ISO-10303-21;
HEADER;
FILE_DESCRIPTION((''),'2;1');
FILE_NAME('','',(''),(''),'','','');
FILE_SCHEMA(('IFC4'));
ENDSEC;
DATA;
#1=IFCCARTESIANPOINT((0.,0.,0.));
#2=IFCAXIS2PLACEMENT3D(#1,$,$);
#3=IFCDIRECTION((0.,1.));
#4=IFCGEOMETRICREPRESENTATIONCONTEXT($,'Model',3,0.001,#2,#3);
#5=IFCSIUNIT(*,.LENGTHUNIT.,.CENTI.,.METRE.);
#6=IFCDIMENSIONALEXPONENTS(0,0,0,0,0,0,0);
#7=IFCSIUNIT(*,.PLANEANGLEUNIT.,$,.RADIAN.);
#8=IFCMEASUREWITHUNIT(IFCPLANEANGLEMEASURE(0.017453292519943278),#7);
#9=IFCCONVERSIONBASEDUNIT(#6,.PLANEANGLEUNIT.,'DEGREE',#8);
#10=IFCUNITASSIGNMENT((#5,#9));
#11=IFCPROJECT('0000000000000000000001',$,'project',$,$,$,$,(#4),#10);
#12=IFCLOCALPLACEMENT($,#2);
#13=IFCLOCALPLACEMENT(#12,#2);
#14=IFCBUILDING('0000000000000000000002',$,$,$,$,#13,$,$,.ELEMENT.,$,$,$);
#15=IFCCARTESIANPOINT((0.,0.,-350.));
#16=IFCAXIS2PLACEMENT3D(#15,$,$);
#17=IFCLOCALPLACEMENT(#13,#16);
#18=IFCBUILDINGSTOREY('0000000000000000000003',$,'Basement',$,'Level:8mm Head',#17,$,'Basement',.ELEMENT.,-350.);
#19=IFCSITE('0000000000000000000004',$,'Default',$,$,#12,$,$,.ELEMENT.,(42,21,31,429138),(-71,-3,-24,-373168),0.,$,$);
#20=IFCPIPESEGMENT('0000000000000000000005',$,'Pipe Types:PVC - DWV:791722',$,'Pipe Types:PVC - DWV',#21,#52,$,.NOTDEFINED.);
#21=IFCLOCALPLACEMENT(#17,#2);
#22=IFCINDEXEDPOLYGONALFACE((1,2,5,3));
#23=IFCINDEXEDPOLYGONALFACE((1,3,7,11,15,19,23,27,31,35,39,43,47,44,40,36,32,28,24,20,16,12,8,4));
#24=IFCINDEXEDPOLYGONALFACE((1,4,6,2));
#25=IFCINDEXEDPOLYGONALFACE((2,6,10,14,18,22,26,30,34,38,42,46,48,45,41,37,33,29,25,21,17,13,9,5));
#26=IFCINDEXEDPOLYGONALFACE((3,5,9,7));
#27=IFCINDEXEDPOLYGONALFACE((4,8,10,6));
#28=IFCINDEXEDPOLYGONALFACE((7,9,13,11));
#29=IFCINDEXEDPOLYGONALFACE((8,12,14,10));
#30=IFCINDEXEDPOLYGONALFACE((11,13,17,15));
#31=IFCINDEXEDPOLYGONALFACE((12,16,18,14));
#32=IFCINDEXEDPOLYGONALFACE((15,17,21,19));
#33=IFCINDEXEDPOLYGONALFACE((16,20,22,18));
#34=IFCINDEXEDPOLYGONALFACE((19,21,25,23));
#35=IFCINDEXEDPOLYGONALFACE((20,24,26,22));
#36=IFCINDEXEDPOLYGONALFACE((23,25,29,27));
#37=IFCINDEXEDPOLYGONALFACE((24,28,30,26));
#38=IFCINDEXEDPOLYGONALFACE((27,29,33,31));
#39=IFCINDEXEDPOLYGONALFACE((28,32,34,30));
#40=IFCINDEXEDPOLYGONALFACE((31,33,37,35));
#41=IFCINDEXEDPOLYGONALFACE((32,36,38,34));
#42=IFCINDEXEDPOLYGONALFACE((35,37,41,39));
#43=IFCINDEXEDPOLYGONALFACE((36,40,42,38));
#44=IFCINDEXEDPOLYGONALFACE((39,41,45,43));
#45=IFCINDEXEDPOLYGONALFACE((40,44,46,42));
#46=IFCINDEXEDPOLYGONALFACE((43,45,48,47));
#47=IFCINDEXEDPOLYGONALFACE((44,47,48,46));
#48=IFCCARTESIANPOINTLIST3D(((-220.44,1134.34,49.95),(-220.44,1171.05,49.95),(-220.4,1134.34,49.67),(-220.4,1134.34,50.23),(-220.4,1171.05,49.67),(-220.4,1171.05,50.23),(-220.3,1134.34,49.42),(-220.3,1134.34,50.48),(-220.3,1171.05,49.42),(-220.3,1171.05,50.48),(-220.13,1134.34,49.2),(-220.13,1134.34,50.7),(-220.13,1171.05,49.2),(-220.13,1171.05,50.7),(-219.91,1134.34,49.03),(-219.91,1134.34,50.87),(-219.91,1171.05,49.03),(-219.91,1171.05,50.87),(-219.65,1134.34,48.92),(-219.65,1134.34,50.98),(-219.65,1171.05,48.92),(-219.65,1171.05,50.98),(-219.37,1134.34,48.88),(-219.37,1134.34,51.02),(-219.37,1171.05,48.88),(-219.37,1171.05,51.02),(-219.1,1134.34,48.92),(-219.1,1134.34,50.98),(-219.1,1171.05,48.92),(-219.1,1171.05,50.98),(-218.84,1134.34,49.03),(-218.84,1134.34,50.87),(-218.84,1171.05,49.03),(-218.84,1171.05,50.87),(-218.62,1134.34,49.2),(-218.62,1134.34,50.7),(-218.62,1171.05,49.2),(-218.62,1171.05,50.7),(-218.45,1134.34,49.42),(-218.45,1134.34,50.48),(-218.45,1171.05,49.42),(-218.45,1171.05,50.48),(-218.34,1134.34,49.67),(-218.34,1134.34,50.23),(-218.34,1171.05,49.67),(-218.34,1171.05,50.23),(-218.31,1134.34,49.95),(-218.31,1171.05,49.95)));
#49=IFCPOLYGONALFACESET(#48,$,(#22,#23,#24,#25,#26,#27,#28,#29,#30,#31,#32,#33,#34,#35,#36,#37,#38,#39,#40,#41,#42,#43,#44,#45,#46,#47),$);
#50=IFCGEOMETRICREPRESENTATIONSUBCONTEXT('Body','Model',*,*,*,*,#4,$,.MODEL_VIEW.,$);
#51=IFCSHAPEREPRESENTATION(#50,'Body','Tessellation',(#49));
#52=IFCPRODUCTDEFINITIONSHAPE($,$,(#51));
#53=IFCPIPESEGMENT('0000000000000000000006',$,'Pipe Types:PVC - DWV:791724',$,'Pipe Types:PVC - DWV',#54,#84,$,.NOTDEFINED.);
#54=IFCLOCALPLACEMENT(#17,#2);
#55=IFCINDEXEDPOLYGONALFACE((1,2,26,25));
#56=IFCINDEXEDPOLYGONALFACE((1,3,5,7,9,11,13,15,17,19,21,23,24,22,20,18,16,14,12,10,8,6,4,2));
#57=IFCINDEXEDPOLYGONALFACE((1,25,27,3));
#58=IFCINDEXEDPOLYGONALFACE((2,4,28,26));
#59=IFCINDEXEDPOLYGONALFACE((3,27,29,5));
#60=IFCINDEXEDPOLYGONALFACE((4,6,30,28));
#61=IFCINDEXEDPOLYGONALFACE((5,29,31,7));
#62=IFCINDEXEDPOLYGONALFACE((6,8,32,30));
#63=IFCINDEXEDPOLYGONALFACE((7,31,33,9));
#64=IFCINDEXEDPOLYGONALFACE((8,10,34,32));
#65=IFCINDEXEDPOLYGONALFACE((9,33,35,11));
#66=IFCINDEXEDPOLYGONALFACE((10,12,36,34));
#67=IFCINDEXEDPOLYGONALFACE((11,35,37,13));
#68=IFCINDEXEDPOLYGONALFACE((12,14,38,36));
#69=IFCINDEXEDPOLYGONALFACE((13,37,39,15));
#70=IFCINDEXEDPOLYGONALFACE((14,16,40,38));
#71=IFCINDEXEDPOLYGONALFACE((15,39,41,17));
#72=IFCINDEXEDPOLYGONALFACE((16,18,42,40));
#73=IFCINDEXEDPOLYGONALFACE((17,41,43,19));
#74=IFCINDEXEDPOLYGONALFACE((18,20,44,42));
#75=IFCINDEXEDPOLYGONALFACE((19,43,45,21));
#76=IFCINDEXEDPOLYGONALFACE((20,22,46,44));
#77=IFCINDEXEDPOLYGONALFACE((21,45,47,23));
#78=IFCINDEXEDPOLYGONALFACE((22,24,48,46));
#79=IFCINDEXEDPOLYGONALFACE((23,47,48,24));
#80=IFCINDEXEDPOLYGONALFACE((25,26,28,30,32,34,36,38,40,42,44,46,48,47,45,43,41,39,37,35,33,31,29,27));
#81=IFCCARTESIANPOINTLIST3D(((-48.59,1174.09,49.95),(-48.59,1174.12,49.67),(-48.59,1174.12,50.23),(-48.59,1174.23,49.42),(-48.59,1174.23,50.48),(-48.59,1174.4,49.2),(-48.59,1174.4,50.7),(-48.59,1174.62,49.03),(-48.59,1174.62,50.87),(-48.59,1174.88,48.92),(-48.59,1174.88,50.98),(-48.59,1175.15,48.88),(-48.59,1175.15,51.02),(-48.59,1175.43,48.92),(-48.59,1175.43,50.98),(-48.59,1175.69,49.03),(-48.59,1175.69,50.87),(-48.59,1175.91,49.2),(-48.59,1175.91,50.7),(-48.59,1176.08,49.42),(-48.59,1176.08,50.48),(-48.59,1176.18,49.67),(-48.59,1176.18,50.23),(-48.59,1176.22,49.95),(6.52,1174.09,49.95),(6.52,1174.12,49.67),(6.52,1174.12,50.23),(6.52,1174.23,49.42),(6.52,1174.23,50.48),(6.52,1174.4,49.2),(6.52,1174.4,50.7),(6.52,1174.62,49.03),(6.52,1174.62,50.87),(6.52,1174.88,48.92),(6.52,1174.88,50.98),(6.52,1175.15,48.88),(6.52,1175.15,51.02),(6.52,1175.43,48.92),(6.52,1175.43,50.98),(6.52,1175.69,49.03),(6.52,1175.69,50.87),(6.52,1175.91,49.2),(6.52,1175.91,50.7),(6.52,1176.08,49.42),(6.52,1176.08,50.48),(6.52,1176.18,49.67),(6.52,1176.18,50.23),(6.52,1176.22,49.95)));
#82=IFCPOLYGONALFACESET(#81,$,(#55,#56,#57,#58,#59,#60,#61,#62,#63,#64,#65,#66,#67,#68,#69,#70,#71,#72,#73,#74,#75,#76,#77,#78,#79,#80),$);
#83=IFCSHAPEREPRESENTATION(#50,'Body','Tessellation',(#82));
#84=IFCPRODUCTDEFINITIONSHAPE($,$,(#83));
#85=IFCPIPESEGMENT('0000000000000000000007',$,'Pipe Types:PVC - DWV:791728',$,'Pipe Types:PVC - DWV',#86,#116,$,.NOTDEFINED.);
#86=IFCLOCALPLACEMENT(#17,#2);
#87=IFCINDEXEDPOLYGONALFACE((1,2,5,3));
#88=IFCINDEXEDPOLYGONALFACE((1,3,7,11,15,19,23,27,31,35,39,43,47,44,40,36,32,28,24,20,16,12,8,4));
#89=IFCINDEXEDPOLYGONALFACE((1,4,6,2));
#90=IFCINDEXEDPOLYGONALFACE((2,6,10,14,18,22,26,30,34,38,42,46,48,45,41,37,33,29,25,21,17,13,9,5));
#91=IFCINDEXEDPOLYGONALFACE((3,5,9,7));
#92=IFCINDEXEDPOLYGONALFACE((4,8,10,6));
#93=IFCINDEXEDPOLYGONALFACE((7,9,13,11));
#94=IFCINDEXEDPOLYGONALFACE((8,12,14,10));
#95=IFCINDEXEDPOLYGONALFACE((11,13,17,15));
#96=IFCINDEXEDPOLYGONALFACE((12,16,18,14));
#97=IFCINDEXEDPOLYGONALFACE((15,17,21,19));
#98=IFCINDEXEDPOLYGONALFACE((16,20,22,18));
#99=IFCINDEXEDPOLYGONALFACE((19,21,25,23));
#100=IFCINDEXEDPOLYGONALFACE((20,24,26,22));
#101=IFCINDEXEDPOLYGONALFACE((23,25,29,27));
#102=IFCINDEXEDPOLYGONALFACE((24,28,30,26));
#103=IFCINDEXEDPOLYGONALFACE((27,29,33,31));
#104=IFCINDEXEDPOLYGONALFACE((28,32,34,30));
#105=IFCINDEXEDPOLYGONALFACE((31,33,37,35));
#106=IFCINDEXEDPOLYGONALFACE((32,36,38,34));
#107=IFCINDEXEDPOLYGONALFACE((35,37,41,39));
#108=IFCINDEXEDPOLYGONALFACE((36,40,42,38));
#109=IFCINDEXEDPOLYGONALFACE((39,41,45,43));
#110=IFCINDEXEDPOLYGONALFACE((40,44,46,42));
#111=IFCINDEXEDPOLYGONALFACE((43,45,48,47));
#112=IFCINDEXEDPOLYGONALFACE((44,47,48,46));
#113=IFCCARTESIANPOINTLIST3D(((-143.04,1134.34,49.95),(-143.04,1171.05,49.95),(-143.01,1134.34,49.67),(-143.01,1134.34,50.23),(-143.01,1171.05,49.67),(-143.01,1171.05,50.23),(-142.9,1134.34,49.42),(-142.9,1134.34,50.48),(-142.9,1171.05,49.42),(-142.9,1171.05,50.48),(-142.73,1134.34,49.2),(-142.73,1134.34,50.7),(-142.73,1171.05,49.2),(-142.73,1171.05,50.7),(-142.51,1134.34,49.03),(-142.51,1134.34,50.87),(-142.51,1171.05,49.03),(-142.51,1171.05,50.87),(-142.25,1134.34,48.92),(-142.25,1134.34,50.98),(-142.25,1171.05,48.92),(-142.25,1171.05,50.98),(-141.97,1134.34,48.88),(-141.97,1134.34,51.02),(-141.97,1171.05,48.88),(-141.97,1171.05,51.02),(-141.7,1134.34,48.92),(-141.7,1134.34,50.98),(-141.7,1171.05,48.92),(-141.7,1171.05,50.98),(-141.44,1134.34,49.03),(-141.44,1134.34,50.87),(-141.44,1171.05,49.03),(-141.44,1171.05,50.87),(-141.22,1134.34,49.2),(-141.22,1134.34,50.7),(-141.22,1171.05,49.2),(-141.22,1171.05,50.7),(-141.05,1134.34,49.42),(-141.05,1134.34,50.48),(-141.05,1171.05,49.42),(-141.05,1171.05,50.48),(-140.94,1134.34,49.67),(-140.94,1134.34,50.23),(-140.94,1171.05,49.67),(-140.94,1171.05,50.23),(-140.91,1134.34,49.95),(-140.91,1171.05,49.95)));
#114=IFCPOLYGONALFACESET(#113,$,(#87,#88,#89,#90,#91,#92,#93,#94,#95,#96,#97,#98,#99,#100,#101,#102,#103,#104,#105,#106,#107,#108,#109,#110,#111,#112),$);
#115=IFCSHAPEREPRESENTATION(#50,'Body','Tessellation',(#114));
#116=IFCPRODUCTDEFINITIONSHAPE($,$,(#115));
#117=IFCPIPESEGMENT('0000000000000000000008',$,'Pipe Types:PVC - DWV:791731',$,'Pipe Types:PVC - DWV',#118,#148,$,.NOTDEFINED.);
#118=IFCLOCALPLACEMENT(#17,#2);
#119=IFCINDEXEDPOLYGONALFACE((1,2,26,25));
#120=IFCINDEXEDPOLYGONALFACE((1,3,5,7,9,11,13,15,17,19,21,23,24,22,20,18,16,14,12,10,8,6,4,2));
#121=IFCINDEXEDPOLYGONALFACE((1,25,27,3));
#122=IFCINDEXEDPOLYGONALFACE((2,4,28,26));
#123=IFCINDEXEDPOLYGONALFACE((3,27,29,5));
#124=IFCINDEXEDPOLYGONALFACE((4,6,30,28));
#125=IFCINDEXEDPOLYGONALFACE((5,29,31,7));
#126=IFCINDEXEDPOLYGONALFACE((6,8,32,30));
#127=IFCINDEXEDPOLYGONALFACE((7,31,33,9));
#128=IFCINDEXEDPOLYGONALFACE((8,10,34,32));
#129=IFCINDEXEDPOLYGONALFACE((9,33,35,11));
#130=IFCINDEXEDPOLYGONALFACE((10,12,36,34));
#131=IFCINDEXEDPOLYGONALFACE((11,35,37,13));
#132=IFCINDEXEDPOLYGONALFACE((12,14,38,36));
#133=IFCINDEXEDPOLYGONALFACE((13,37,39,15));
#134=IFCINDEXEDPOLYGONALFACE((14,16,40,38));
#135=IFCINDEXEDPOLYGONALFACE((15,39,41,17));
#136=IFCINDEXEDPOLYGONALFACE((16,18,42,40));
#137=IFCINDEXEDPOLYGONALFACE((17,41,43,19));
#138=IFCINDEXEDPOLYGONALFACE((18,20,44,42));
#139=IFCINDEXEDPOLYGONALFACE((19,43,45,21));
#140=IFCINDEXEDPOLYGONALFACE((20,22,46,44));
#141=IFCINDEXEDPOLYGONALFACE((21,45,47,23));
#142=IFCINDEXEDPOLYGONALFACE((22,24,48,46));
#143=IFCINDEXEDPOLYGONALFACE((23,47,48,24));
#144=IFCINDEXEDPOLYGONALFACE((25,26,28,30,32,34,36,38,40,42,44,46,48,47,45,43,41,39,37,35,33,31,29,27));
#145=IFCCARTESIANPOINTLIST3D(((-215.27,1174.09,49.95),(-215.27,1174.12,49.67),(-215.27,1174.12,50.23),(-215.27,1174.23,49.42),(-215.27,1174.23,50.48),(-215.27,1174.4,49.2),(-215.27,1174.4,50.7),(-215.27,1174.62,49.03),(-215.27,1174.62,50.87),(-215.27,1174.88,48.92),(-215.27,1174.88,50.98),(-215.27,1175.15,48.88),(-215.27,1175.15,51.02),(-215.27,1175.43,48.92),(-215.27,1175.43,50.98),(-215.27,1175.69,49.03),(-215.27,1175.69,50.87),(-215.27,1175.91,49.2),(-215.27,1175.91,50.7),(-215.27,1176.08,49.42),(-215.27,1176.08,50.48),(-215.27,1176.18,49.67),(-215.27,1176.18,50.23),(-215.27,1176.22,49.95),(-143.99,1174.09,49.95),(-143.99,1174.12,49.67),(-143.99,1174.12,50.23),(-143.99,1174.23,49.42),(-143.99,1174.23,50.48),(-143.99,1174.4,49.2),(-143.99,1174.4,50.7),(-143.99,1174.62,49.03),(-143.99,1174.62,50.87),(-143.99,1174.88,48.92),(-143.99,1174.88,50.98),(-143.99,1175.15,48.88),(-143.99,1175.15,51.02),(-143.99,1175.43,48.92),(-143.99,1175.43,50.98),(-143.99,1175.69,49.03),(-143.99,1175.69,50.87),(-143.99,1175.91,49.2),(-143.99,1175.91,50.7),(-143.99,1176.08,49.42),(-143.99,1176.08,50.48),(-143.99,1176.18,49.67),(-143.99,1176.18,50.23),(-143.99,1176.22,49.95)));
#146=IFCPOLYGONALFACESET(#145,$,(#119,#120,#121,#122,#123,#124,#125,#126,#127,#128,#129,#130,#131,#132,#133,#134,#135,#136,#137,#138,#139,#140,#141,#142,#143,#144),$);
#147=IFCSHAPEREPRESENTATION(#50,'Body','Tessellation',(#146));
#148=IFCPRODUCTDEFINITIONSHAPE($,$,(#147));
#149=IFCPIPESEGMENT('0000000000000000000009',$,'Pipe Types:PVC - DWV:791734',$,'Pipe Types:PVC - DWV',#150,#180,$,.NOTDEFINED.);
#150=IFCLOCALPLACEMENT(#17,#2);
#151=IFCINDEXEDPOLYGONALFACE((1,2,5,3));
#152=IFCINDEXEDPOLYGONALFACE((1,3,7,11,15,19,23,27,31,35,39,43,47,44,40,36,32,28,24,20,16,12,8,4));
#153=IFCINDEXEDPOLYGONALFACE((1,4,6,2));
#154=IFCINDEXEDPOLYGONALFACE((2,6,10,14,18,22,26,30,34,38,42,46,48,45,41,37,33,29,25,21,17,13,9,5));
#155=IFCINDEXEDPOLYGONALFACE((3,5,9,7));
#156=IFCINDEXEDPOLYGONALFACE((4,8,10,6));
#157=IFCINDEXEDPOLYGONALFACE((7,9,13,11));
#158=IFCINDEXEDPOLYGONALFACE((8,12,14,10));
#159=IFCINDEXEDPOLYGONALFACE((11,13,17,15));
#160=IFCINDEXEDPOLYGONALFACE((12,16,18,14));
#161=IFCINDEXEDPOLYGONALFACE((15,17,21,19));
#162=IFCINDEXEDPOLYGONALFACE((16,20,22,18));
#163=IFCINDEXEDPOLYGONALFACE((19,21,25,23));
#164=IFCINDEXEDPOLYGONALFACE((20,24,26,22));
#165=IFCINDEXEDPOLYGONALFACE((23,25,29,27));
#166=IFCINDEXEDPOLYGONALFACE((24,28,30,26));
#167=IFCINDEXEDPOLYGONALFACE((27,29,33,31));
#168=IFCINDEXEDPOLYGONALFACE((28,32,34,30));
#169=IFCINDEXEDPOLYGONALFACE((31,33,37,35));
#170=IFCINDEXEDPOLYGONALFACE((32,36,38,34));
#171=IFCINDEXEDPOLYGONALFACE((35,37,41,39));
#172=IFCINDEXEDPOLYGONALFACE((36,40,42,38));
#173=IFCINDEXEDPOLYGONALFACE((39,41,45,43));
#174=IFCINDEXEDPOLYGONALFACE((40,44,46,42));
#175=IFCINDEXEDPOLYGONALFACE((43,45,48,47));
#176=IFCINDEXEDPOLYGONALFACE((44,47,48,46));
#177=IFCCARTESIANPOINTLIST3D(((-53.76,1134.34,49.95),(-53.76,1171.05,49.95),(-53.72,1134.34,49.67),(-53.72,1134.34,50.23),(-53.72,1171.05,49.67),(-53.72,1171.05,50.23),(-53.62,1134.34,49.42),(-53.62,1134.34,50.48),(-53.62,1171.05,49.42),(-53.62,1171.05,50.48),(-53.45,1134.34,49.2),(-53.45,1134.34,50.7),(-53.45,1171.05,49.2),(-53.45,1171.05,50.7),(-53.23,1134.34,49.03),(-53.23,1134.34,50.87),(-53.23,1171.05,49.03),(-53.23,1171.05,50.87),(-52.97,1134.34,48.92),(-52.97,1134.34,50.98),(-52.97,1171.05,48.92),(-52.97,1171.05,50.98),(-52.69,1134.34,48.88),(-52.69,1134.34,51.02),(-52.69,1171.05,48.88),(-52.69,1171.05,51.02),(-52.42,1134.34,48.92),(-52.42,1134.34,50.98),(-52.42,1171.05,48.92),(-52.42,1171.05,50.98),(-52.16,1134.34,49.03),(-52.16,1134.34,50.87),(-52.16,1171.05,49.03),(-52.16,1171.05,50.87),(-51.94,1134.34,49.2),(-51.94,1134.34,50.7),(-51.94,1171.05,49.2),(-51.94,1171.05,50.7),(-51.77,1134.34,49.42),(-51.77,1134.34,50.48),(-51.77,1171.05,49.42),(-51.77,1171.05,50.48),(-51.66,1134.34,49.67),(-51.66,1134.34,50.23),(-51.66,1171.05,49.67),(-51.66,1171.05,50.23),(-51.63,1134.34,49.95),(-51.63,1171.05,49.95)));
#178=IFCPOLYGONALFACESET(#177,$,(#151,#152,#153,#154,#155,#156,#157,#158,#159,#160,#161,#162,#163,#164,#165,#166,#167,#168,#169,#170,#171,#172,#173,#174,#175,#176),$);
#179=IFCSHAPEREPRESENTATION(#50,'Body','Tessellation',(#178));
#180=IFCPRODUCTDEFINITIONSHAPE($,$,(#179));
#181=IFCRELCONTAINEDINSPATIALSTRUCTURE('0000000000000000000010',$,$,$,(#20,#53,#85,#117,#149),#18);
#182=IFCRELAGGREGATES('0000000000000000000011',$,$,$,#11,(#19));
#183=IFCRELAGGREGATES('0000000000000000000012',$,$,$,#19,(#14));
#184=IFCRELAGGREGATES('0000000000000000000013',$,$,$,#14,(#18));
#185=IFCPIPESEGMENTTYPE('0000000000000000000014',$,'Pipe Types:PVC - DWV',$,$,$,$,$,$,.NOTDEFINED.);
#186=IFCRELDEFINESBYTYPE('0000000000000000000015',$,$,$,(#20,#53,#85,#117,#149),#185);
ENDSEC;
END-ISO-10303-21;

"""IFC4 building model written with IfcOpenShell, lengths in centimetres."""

from ifc_helpers import new_model, entity, si_unit, converted_unit, direction, frame, origin, place, context, subcontext, project, spatial, arc, indexed_curve, outline, extrude, type_object, element, save


model = new_model("IFC4")

# Units and contexts
model_context = context("Model", 3, precision=0.001, world=origin(), true_north=direction((0.0, 1.0)))
body_context = subcontext(model_context, "Body", "Model", "MODEL_VIEW")
ifc_project = project(units=[si_unit("LENGTHUNIT", "METRE", prefix="CENTI"), converted_unit("PLANEANGLEUNIT", "DEGREE", entity("IfcPlaneAngleMeasure", 0.017453292519943278), si_unit("PLANEANGLEUNIT", "RADIAN"), dimensions=[0, 0, 0, 0, 0, 0, 0])], contexts=[model_context])

# Site, building, storey
site_placement = place(None, origin())
site = spatial("IfcSite", under=ifc_project, at=site_placement, Name="Default", CompositionType="ELEMENT", RefLatitude=(42, 21, 31, 429138), RefLongitude=(-71, -3, -24, -373168), RefElevation=0.0)
building_placement = place(site_placement, origin())
building = spatial("IfcBuilding", under=site, at=building_placement, CompositionType="ELEMENT")
storey_placement = place(building_placement, frame((0.0, 0.0, -350.0)))
storey = spatial("IfcBuildingStorey", under=building, at=storey_placement, Name="Basement", ObjectType="Level:8mm Head", LongName="Basement", CompositionType="ELEMENT", Elevation=-350.0)

# Pipe segments
pipe_segment_type = type_object("IfcPipeSegmentType", Name="Pipe Types:PVC - DWV", PredefinedType="NOTDEFINED")
pipe_segment_1_placement = place(storey_placement, origin())
element("IfcPipeSegment", 1, at=pipe_segment_1_placement, inside=storey, type_object=pipe_segment_type, Name="Pipe Types:PVC - DWV:791722", ObjectType="Pipe Types:PVC - DWV", PredefinedType="NOTDEFINED", context=body_context, shape_type="SweptSolid", body=[
    extrude(outline(indexed_curve([(1.07, 0.0), (0.75, 0.75), (0.0, 1.07), (-0.75, 0.75), (-1.07, 0.0), (-0.75, -0.75), (0.0, -1.07), (0.75, -0.75)], segments=[arc(1, 2, 3), arc(3, 4, 5), arc(5, 6, 7), arc(7, 8, 1)], self_intersect=False)), frame((-219.37, 1134.34, 49.95), z_axis=(0.0, 1.0, 0.0), x_axis=(1.0, 0.0, 0.0)), (0.0, 0.0, 1.0), 36.71),
])
pipe_segment_2_placement = place(storey_placement, origin())
element("IfcPipeSegment", 2, at=pipe_segment_2_placement, inside=storey, type_object=pipe_segment_type, Name="Pipe Types:PVC - DWV:791724", ObjectType="Pipe Types:PVC - DWV", PredefinedType="NOTDEFINED", context=body_context, shape_type="SweptSolid", body=[
    extrude(outline(indexed_curve([(1.07, 0.0), (0.75, 0.75), (0.0, 1.07), (-0.75, 0.75), (-1.07, 0.0), (-0.75, -0.75), (0.0, -1.07), (0.75, -0.75)], segments=[arc(1, 2, 3), arc(3, 4, 5), arc(5, 6, 7), arc(7, 8, 1)], self_intersect=False)), frame((-48.59, 1175.15, 49.95), z_axis=(1.0, 0.0, 0.0), x_axis=(0.0, -1.0, 0.0)), (0.0, 0.0, 1.0), 55.11),
])
pipe_segment_3_placement = place(storey_placement, origin())
element("IfcPipeSegment", 3, at=pipe_segment_3_placement, inside=storey, type_object=pipe_segment_type, Name="Pipe Types:PVC - DWV:791728", ObjectType="Pipe Types:PVC - DWV", PredefinedType="NOTDEFINED", context=body_context, shape_type="SweptSolid", body=[
    extrude(outline(indexed_curve([(1.07, 0.0), (0.75, 0.75), (0.0, 1.07), (-0.75, 0.75), (-1.07, 0.0), (-0.75, -0.75), (0.0, -1.07), (0.75, -0.75)], segments=[arc(1, 2, 3), arc(3, 4, 5), arc(5, 6, 7), arc(7, 8, 1)], self_intersect=False)), frame((-141.97, 1134.34, 49.95), z_axis=(0.0, 1.0, 0.0), x_axis=(-1.0, 0.0, 0.0)), (0.0, 0.0, 1.0), 36.71),
])
pipe_segment_4_placement = place(storey_placement, origin())
element("IfcPipeSegment", 4, at=pipe_segment_4_placement, inside=storey, type_object=pipe_segment_type, Name="Pipe Types:PVC - DWV:791731", ObjectType="Pipe Types:PVC - DWV", PredefinedType="NOTDEFINED", context=body_context, shape_type="SweptSolid", body=[
    extrude(outline(indexed_curve([(1.07, 0.0), (0.75, 0.75), (0.0, 1.07), (-0.75, 0.75), (-1.07, 0.0), (-0.75, -0.75), (0.0, -1.07), (0.75, -0.75)], segments=[arc(1, 2, 3), arc(3, 4, 5), arc(5, 6, 7), arc(7, 8, 1)], self_intersect=False)), frame((-215.27, 1175.15, 49.95), z_axis=(1.0, 0.0, 0.0), x_axis=(0.0, -1.0, 0.0)), (0.0, 0.0, 1.0), 71.29),
])
pipe_segment_5_placement = place(storey_placement, origin())
element("IfcPipeSegment", 5, at=pipe_segment_5_placement, inside=storey, type_object=pipe_segment_type, Name="Pipe Types:PVC - DWV:791734", ObjectType="Pipe Types:PVC - DWV", PredefinedType="NOTDEFINED", context=body_context, shape_type="SweptSolid", body=[
    extrude(outline(indexed_curve([(1.07, 0.0), (0.75, 0.75), (0.0, 1.07), (-0.75, 0.75), (-1.07, 0.0), (-0.75, -0.75), (0.0, -1.07), (0.75, -0.75)], segments=[arc(1, 2, 3), arc(3, 4, 5), arc(5, 6, 7), arc(7, 8, 1)], self_intersect=False)), frame((-52.69, 1134.34, 49.95), z_axis=(0.0, 1.0, 0.0), x_axis=(-1.0, 0.0, 0.0)), (0.0, 0.0, 1.0), 36.71),
])

save(model, "model.ifc")
